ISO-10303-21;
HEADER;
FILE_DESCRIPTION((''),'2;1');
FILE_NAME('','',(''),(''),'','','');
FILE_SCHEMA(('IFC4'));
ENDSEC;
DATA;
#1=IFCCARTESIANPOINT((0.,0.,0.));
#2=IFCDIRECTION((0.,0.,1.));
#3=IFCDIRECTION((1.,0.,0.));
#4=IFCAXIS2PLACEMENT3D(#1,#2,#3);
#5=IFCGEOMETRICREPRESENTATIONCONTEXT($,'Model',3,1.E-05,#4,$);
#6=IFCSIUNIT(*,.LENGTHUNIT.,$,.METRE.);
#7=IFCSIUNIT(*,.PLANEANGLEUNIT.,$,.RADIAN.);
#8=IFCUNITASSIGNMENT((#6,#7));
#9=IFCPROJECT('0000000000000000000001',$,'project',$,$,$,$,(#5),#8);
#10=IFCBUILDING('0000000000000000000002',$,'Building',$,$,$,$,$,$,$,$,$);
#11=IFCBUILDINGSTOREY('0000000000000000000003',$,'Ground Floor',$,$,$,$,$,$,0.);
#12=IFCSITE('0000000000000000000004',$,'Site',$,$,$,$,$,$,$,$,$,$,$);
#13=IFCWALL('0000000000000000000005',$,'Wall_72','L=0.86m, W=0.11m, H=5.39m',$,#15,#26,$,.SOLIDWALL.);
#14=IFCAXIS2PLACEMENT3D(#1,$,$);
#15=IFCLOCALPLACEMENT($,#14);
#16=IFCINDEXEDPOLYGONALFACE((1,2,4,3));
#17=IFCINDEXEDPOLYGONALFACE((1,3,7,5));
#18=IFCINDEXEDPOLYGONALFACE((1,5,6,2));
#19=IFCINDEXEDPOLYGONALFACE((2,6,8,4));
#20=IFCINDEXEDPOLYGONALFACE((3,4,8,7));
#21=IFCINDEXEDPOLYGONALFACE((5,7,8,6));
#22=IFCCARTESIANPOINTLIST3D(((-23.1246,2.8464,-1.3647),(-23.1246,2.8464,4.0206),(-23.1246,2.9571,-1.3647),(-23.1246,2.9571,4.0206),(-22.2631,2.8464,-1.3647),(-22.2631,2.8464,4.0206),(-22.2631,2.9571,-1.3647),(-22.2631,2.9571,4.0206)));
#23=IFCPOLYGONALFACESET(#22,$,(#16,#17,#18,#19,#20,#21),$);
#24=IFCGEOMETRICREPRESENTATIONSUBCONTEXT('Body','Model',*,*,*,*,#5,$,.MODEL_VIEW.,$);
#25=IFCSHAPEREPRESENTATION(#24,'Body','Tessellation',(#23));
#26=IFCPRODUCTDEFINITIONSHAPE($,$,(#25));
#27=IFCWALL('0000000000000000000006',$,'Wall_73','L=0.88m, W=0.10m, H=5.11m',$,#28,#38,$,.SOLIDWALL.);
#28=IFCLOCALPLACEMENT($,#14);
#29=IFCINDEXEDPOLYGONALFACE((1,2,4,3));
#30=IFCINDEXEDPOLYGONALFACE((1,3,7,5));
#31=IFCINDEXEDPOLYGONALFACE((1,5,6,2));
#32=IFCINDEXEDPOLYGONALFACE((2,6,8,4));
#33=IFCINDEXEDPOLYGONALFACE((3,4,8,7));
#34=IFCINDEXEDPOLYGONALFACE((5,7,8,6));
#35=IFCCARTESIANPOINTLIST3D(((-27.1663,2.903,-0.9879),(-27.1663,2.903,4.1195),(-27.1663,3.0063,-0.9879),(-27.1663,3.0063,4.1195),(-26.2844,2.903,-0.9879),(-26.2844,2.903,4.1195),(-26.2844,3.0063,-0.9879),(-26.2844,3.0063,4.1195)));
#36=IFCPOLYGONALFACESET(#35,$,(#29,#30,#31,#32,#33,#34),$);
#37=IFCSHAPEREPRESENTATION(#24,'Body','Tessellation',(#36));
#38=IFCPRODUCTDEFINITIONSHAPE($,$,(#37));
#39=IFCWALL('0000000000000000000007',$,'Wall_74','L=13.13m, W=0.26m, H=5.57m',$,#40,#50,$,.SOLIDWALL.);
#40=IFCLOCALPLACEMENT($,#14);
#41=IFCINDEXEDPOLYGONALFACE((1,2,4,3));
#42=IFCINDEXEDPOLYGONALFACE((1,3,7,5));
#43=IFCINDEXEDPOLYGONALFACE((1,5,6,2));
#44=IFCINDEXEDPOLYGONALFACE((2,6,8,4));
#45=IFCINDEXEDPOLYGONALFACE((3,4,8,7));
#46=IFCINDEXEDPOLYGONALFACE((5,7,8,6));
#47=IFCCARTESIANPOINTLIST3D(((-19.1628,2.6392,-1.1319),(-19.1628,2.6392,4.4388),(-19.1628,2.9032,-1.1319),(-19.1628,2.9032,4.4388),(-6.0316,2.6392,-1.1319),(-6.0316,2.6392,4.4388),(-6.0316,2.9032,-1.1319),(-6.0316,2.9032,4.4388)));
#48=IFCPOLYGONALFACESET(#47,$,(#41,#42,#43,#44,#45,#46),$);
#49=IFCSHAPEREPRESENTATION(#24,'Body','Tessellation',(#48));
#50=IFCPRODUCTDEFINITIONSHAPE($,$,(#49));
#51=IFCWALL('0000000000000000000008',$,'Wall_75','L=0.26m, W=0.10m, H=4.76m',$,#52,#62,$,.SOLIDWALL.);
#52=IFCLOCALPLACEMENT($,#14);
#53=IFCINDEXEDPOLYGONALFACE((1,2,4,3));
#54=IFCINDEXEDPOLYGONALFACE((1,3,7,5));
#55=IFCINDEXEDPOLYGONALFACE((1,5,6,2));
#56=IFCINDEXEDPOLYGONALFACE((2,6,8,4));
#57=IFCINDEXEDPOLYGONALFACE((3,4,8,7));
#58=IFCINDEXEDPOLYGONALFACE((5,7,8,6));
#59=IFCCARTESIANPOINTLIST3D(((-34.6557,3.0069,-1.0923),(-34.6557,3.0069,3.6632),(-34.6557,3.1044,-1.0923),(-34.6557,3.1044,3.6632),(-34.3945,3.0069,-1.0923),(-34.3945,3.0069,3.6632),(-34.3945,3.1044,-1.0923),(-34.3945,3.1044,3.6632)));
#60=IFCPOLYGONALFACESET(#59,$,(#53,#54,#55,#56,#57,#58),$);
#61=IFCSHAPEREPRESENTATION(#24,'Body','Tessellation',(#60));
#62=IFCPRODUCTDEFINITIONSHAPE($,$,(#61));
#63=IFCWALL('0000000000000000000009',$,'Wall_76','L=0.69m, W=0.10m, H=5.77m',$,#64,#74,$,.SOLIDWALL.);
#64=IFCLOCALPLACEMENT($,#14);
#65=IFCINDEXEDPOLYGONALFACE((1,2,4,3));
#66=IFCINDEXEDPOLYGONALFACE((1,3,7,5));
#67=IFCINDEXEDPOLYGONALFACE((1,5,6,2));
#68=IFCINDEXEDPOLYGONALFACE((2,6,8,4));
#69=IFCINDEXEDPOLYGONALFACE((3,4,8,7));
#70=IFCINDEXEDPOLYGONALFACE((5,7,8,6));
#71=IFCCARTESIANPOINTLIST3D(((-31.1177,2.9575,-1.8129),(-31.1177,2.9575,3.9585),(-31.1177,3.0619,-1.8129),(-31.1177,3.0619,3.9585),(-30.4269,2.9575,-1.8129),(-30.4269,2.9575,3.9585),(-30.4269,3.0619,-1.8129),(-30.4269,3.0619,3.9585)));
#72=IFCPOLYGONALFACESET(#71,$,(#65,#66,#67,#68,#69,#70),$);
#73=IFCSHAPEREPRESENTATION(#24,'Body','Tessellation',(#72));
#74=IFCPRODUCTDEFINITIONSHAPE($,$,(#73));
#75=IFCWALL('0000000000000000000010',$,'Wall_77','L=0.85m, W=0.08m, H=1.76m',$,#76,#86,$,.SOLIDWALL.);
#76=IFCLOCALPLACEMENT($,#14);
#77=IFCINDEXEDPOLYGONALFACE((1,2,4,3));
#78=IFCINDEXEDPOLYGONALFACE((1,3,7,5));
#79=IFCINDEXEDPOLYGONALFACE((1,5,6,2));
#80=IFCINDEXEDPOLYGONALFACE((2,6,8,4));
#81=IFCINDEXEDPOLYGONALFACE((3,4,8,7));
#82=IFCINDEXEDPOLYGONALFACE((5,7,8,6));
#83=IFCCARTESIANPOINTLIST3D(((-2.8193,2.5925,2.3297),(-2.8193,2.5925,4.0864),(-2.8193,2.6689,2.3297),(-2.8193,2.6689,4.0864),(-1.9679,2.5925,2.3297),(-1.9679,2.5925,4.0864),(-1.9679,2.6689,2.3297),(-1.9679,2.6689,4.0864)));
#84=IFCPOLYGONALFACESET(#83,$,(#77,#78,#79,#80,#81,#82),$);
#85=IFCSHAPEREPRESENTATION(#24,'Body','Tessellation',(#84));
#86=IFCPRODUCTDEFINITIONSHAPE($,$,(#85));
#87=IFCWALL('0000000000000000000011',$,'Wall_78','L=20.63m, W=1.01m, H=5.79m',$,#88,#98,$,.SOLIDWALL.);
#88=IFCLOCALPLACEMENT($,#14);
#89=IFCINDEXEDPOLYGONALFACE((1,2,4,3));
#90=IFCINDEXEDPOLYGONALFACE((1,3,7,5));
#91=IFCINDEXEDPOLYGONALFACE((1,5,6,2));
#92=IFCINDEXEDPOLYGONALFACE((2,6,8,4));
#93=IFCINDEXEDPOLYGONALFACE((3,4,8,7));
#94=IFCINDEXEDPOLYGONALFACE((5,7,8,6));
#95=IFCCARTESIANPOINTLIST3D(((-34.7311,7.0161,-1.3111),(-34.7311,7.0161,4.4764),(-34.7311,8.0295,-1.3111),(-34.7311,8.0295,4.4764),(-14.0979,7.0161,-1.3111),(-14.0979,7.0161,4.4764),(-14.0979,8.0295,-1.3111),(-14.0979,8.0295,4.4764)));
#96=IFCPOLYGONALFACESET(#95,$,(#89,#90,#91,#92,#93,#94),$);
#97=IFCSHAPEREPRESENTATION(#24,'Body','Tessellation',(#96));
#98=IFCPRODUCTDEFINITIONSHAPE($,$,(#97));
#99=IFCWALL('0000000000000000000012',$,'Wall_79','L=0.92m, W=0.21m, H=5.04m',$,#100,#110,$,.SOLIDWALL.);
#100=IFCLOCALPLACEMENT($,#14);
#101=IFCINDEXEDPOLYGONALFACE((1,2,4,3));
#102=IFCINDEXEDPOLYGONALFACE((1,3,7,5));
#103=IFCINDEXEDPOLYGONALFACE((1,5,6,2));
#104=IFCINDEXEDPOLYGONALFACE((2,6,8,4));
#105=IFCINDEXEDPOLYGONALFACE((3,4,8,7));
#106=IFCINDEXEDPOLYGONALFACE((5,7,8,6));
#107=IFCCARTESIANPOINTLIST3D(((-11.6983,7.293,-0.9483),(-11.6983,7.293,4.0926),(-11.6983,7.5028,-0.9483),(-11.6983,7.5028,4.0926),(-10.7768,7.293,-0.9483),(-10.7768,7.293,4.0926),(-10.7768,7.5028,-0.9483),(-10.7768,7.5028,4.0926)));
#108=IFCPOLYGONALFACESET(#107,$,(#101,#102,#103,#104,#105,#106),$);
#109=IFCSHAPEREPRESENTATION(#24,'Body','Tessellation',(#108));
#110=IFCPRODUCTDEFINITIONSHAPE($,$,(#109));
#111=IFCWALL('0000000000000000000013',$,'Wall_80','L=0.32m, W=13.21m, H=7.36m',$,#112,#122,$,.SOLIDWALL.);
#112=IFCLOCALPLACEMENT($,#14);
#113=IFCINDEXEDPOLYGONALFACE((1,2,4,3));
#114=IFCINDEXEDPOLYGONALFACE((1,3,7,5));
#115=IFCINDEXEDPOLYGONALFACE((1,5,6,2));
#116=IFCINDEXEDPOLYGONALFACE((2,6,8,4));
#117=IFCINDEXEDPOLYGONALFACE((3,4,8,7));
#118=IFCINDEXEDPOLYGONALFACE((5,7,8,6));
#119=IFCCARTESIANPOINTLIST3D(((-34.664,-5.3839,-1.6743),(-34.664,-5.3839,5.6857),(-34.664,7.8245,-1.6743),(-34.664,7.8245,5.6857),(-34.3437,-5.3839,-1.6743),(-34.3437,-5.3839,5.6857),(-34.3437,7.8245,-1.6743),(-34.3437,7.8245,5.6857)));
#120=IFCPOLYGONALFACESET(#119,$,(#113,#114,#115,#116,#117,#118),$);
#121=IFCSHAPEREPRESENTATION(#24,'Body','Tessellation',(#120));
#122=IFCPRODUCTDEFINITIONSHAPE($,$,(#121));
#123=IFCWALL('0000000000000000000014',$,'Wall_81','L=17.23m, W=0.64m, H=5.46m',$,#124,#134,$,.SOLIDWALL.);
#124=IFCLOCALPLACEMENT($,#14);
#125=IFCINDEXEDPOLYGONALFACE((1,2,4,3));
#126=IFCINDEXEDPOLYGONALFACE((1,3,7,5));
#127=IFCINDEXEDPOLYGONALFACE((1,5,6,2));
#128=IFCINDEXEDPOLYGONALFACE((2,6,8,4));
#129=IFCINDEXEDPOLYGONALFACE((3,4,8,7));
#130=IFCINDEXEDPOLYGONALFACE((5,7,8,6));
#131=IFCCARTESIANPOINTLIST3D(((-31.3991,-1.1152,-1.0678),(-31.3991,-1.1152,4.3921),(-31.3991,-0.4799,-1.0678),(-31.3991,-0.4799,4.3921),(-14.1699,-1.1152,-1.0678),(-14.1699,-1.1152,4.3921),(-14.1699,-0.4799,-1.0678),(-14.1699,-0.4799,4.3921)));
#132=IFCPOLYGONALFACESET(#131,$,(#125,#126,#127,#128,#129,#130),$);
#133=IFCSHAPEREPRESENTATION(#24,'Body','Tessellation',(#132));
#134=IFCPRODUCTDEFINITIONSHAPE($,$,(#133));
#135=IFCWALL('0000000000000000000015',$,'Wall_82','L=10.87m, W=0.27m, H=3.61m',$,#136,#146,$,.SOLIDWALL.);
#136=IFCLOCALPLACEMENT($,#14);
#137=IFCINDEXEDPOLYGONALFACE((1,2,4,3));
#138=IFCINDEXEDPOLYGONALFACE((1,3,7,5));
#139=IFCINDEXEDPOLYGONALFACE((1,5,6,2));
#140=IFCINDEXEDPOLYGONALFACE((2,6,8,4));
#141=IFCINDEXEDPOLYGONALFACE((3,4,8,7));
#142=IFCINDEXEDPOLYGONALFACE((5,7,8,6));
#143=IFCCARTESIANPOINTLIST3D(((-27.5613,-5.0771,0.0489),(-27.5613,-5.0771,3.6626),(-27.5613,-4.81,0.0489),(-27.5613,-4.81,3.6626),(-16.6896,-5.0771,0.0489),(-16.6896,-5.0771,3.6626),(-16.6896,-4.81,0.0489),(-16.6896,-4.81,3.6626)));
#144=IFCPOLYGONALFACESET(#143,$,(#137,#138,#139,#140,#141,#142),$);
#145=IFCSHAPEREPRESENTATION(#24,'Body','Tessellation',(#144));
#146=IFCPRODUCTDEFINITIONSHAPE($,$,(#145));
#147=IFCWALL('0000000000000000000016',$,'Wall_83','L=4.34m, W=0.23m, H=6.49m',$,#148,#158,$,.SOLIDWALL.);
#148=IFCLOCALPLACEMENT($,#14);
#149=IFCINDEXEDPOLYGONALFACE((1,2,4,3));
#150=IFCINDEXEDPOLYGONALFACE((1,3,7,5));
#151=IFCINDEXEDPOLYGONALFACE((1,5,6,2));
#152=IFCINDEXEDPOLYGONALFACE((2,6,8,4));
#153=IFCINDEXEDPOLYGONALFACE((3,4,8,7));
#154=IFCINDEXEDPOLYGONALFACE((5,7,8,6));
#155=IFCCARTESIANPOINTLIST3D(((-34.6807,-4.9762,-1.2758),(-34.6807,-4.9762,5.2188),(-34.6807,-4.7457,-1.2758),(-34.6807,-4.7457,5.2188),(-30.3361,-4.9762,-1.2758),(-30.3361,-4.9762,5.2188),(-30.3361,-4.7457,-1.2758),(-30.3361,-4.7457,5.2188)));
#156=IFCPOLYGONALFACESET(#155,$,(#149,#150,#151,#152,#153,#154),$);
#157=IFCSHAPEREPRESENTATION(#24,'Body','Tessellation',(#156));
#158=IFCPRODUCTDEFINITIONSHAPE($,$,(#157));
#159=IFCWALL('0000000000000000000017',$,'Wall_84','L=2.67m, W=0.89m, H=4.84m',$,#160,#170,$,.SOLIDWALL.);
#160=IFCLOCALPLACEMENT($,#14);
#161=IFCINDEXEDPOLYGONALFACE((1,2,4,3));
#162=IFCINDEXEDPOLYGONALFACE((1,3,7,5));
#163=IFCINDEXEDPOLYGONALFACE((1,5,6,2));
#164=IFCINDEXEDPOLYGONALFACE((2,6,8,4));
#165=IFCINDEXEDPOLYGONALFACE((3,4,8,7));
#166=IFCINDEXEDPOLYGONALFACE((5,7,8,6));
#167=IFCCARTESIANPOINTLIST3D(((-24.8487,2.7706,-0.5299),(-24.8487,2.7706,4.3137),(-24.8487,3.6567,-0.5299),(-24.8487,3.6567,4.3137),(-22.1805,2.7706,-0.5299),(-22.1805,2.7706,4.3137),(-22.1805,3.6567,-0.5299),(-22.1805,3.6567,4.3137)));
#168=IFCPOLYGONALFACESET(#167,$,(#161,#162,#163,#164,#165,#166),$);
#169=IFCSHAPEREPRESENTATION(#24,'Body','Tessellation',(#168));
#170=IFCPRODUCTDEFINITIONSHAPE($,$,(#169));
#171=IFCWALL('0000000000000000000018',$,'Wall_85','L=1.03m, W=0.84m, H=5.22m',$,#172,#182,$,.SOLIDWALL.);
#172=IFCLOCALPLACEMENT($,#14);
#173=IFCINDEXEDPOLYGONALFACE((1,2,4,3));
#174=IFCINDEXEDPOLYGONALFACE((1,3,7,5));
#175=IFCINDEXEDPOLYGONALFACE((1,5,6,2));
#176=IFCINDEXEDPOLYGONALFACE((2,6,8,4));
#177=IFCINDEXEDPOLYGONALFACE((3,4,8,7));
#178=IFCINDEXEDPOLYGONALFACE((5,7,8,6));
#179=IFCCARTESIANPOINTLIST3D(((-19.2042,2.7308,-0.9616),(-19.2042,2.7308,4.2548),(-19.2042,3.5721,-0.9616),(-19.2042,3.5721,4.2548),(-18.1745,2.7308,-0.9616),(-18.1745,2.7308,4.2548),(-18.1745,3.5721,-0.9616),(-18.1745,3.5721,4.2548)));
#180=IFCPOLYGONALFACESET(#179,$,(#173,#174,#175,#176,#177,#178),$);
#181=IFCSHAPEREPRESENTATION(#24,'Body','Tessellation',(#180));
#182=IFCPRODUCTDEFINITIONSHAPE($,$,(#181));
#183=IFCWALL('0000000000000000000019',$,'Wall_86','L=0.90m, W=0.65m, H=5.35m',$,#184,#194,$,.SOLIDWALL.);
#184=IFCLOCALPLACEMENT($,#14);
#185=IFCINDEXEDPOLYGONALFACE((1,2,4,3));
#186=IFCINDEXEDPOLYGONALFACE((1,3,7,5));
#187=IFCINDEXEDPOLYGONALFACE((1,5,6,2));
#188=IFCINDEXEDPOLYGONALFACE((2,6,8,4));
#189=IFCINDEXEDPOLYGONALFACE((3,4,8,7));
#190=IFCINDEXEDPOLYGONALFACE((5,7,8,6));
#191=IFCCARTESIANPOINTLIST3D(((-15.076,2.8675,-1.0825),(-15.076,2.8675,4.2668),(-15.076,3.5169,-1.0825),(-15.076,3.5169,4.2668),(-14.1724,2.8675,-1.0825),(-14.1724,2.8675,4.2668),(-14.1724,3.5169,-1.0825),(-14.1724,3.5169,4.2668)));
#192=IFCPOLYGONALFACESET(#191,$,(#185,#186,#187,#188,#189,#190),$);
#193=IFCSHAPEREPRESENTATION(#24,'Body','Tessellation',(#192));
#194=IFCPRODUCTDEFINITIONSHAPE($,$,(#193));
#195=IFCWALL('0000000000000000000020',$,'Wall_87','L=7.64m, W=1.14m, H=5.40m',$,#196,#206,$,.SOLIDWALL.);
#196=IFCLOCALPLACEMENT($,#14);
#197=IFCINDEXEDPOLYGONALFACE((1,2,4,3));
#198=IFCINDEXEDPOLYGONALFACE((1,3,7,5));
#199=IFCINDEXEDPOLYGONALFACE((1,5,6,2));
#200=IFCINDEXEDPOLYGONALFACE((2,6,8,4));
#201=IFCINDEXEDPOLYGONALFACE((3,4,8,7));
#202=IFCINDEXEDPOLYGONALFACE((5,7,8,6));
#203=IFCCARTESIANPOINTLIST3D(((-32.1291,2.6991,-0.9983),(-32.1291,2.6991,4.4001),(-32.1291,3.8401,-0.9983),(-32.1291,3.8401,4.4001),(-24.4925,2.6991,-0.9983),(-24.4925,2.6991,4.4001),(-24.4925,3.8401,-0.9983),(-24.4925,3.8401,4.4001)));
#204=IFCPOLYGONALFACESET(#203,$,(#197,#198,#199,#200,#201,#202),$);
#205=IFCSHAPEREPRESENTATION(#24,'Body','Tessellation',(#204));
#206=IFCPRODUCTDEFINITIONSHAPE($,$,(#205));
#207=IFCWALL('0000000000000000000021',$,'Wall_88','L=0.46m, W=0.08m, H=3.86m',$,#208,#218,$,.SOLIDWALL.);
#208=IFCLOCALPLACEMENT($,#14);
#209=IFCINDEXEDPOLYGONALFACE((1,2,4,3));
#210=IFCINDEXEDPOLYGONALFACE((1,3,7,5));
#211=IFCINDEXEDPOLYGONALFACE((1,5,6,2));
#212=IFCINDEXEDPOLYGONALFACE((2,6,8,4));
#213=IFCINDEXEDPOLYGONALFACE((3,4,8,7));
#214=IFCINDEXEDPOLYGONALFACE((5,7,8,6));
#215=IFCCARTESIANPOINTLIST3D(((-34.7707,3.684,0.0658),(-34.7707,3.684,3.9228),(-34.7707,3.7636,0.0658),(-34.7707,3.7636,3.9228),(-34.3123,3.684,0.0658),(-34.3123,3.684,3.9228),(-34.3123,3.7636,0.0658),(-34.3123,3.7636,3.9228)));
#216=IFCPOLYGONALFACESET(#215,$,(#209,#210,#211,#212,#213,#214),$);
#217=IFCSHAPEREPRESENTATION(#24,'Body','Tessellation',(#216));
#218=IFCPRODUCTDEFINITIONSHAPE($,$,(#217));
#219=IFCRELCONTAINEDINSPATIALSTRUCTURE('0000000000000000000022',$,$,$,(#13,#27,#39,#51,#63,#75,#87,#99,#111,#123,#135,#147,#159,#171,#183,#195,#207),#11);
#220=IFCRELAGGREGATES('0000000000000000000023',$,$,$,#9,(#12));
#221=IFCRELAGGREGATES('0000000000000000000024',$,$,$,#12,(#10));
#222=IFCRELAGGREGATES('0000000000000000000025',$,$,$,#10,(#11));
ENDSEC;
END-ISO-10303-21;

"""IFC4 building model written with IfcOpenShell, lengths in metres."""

from ifc_helpers import new_model, si_unit, frame, origin_with_axes, origin_2d, context, subcontext, project, spatial, rectangle, extrude, element, save


model = new_model("IFC4")

# Units and contexts
model_context = context("Model", 3, precision=1e-05, world=origin_with_axes())
body_context = subcontext(model_context, "Body", "Model", "MODEL_VIEW")
ifc_project = project(units=[si_unit("LENGTHUNIT", "METRE"), si_unit("PLANEANGLEUNIT", "RADIAN")], contexts=[model_context])

# Site, building, storey
site = spatial("IfcSite", under=ifc_project, Name="Site")
building = spatial("IfcBuilding", under=site, Name="Building")
storey = spatial("IfcBuildingStorey", under=building, Name="Ground Floor", Elevation=0.0)

# Walls
element("IfcWall", 1, inside=storey, Name="Wall_72", Description="L=0.86m, W=0.11m, H=5.39m", PredefinedType="SOLIDWALL", context=body_context, shape_type="SweptSolid", body=[
    extrude(rectangle(XDim=0.8615, YDim=0.1107, at=origin_2d()), frame((-22.6939, 2.9017, -1.3647), z_axis=(0.0, 0.0, 1.0), x_axis=(1.0, 0.0, 0.0)), (0.0, 0.0, 1.0), 5.3853),
])
element("IfcWall", 2, inside=storey, Name="Wall_73", Description="L=0.88m, W=0.10m, H=5.11m", PredefinedType="SOLIDWALL", context=body_context, shape_type="SweptSolid", body=[
    extrude(rectangle(XDim=0.8819, YDim=0.1033, at=origin_2d()), frame((-26.7254, 2.9547, -0.9879), z_axis=(0.0, 0.0, 1.0), x_axis=(1.0, 0.0, 0.0)), (0.0, 0.0, 1.0), 5.1075),
])
element("IfcWall", 3, inside=storey, Name="Wall_74", Description="L=13.13m, W=0.26m, H=5.57m", PredefinedType="SOLIDWALL", context=body_context, shape_type="SweptSolid", body=[
    extrude(rectangle(XDim=13.1312, YDim=0.264, at=origin_2d()), frame((-12.5972, 2.7712, -1.1319), z_axis=(0.0, 0.0, 1.0), x_axis=(1.0, 0.0, 0.0)), (0.0, 0.0, 1.0), 5.5707),
])
element("IfcWall", 4, inside=storey, Name="Wall_75", Description="L=0.26m, W=0.10m, H=4.76m", PredefinedType="SOLIDWALL", context=body_context, shape_type="SweptSolid", body=[
    extrude(rectangle(XDim=0.2612, YDim=0.0975, at=origin_2d()), frame((-34.5251, 3.0556, -1.0923), z_axis=(0.0, 0.0, 1.0), x_axis=(1.0, 0.0, 0.0)), (0.0, 0.0, 1.0), 4.7555),
])
element("IfcWall", 5, inside=storey, Name="Wall_76", Description="L=0.69m, W=0.10m, H=5.77m", PredefinedType="SOLIDWALL", context=body_context, shape_type="SweptSolid", body=[
    extrude(rectangle(XDim=0.6907, YDim=0.1044, at=origin_2d()), frame((-30.7723, 3.0097, -1.8129), z_axis=(0.0, 0.0, 1.0), x_axis=(1.0, 0.0, 0.0)), (0.0, 0.0, 1.0), 5.7715),
])
element("IfcWall", 6, inside=storey, Name="Wall_77", Description="L=0.85m, W=0.08m, H=1.76m", PredefinedType="SOLIDWALL", context=body_context, shape_type="SweptSolid", body=[
    extrude(rectangle(XDim=0.8514, YDim=0.0764, at=origin_2d()), frame((-2.3936, 2.6307, 2.3297), z_axis=(0.0, 0.0, 1.0), x_axis=(1.0, 0.0, 0.0)), (0.0, 0.0, 1.0), 1.7568),
])
element("IfcWall", 7, inside=storey, Name="Wall_78", Description="L=20.63m, W=1.01m, H=5.79m", PredefinedType="SOLIDWALL", context=body_context, shape_type="SweptSolid", body=[
    extrude(rectangle(XDim=20.6332, YDim=1.0133, at=origin_2d()), frame((-24.4145, 7.5228, -1.3111), z_axis=(0.0, 0.0, 1.0), x_axis=(1.0, 0.0, 0.0)), (0.0, 0.0, 1.0), 5.7875),
])
element("IfcWall", 8, inside=storey, Name="Wall_79", Description="L=0.92m, W=0.21m, H=5.04m", PredefinedType="SOLIDWALL", context=body_context, shape_type="SweptSolid", body=[
    extrude(rectangle(XDim=0.9215, YDim=0.2097, at=origin_2d()), frame((-11.2375, 7.3979, -0.9483), z_axis=(0.0, 0.0, 1.0), x_axis=(1.0, 0.0, 0.0)), (0.0, 0.0, 1.0), 5.0409),
])
element("IfcWall", 9, inside=storey, Name="Wall_80", Description="L=0.32m, W=13.21m, H=7.36m", PredefinedType="SOLIDWALL", context=body_context, shape_type="SweptSolid", body=[
    extrude(rectangle(XDim=0.3203, YDim=13.2084, at=origin_2d()), frame((-34.5038, 1.2203, -1.6743), z_axis=(0.0, 0.0, 1.0), x_axis=(1.0, 0.0, 0.0)), (0.0, 0.0, 1.0), 7.36),
])
element("IfcWall", 10, inside=storey, Name="Wall_81", Description="L=17.23m, W=0.64m, H=5.46m", PredefinedType="SOLIDWALL", context=body_context, shape_type="SweptSolid", body=[
    extrude(rectangle(XDim=17.2292, YDim=0.6353, at=origin_2d()), frame((-22.7845, -0.7975, -1.0678), z_axis=(0.0, 0.0, 1.0), x_axis=(1.0, 0.0, 0.0)), (0.0, 0.0, 1.0), 5.4599),
])
element("IfcWall", 11, inside=storey, Name="Wall_82", Description="L=10.87m, W=0.27m, H=3.61m", PredefinedType="SOLIDWALL", context=body_context, shape_type="SweptSolid", body=[
    extrude(rectangle(XDim=10.8717, YDim=0.267, at=origin_2d()), frame((-22.1254, -4.9436, 0.0489), z_axis=(0.0, 0.0, 1.0), x_axis=(1.0, 0.0, 0.0)), (0.0, 0.0, 1.0), 3.6137),
])
element("IfcWall", 12, inside=storey, Name="Wall_83", Description="L=4.34m, W=0.23m, H=6.49m", PredefinedType="SOLIDWALL", context=body_context, shape_type="SweptSolid", body=[
    extrude(rectangle(XDim=4.3446, YDim=0.2305, at=origin_2d()), frame((-32.5084, -4.861, -1.2758), z_axis=(0.0, 0.0, 1.0), x_axis=(1.0, 0.0, 0.0)), (0.0, 0.0, 1.0), 6.4946),
])
element("IfcWall", 13, inside=storey, Name="Wall_84", Description="L=2.67m, W=0.89m, H=4.84m", PredefinedType="SOLIDWALL", context=body_context, shape_type="SweptSolid", body=[
    extrude(rectangle(XDim=2.6682, YDim=0.8861, at=origin_2d()), frame((-23.5146, 3.2136, -0.5299), z_axis=(0.0, 0.0, 1.0), x_axis=(1.0, 0.0, 0.0)), (0.0, 0.0, 1.0), 4.8436),
])
element("IfcWall", 14, inside=storey, Name="Wall_85", Description="L=1.03m, W=0.84m, H=5.22m", PredefinedType="SOLIDWALL", context=body_context, shape_type="SweptSolid", body=[
    extrude(rectangle(XDim=1.0297, YDim=0.8412, at=origin_2d()), frame((-18.6894, 3.1514, -0.9616), z_axis=(0.0, 0.0, 1.0), x_axis=(1.0, 0.0, 0.0)), (0.0, 0.0, 1.0), 5.2164),
])
element("IfcWall", 15, inside=storey, Name="Wall_86", Description="L=0.90m, W=0.65m, H=5.35m", PredefinedType="SOLIDWALL", context=body_context, shape_type="SweptSolid", body=[
    extrude(rectangle(XDim=0.9035, YDim=0.6494, at=origin_2d()), frame((-14.6242, 3.1922, -1.0825), z_axis=(0.0, 0.0, 1.0), x_axis=(1.0, 0.0, 0.0)), (0.0, 0.0, 1.0), 5.3493),
])
element("IfcWall", 16, inside=storey, Name="Wall_87", Description="L=7.64m, W=1.14m, H=5.40m", PredefinedType="SOLIDWALL", context=body_context, shape_type="SweptSolid", body=[
    extrude(rectangle(XDim=7.6367, YDim=1.1411, at=origin_2d()), frame((-28.3108, 3.2696, -0.9983), z_axis=(0.0, 0.0, 1.0), x_axis=(1.0, 0.0, 0.0)), (0.0, 0.0, 1.0), 5.3984),
])
element("IfcWall", 17, inside=storey, Name="Wall_88", Description="L=0.46m, W=0.08m, H=3.86m", PredefinedType="SOLIDWALL", context=body_context, shape_type="SweptSolid", body=[
    extrude(rectangle(XDim=0.4584, YDim=0.0796, at=origin_2d()), frame((-34.5415, 3.7238, 0.0658), z_axis=(0.0, 0.0, 1.0), x_axis=(1.0, 0.0, 0.0)), (0.0, 0.0, 1.0), 3.857),
])

save(model, "model.ifc")
